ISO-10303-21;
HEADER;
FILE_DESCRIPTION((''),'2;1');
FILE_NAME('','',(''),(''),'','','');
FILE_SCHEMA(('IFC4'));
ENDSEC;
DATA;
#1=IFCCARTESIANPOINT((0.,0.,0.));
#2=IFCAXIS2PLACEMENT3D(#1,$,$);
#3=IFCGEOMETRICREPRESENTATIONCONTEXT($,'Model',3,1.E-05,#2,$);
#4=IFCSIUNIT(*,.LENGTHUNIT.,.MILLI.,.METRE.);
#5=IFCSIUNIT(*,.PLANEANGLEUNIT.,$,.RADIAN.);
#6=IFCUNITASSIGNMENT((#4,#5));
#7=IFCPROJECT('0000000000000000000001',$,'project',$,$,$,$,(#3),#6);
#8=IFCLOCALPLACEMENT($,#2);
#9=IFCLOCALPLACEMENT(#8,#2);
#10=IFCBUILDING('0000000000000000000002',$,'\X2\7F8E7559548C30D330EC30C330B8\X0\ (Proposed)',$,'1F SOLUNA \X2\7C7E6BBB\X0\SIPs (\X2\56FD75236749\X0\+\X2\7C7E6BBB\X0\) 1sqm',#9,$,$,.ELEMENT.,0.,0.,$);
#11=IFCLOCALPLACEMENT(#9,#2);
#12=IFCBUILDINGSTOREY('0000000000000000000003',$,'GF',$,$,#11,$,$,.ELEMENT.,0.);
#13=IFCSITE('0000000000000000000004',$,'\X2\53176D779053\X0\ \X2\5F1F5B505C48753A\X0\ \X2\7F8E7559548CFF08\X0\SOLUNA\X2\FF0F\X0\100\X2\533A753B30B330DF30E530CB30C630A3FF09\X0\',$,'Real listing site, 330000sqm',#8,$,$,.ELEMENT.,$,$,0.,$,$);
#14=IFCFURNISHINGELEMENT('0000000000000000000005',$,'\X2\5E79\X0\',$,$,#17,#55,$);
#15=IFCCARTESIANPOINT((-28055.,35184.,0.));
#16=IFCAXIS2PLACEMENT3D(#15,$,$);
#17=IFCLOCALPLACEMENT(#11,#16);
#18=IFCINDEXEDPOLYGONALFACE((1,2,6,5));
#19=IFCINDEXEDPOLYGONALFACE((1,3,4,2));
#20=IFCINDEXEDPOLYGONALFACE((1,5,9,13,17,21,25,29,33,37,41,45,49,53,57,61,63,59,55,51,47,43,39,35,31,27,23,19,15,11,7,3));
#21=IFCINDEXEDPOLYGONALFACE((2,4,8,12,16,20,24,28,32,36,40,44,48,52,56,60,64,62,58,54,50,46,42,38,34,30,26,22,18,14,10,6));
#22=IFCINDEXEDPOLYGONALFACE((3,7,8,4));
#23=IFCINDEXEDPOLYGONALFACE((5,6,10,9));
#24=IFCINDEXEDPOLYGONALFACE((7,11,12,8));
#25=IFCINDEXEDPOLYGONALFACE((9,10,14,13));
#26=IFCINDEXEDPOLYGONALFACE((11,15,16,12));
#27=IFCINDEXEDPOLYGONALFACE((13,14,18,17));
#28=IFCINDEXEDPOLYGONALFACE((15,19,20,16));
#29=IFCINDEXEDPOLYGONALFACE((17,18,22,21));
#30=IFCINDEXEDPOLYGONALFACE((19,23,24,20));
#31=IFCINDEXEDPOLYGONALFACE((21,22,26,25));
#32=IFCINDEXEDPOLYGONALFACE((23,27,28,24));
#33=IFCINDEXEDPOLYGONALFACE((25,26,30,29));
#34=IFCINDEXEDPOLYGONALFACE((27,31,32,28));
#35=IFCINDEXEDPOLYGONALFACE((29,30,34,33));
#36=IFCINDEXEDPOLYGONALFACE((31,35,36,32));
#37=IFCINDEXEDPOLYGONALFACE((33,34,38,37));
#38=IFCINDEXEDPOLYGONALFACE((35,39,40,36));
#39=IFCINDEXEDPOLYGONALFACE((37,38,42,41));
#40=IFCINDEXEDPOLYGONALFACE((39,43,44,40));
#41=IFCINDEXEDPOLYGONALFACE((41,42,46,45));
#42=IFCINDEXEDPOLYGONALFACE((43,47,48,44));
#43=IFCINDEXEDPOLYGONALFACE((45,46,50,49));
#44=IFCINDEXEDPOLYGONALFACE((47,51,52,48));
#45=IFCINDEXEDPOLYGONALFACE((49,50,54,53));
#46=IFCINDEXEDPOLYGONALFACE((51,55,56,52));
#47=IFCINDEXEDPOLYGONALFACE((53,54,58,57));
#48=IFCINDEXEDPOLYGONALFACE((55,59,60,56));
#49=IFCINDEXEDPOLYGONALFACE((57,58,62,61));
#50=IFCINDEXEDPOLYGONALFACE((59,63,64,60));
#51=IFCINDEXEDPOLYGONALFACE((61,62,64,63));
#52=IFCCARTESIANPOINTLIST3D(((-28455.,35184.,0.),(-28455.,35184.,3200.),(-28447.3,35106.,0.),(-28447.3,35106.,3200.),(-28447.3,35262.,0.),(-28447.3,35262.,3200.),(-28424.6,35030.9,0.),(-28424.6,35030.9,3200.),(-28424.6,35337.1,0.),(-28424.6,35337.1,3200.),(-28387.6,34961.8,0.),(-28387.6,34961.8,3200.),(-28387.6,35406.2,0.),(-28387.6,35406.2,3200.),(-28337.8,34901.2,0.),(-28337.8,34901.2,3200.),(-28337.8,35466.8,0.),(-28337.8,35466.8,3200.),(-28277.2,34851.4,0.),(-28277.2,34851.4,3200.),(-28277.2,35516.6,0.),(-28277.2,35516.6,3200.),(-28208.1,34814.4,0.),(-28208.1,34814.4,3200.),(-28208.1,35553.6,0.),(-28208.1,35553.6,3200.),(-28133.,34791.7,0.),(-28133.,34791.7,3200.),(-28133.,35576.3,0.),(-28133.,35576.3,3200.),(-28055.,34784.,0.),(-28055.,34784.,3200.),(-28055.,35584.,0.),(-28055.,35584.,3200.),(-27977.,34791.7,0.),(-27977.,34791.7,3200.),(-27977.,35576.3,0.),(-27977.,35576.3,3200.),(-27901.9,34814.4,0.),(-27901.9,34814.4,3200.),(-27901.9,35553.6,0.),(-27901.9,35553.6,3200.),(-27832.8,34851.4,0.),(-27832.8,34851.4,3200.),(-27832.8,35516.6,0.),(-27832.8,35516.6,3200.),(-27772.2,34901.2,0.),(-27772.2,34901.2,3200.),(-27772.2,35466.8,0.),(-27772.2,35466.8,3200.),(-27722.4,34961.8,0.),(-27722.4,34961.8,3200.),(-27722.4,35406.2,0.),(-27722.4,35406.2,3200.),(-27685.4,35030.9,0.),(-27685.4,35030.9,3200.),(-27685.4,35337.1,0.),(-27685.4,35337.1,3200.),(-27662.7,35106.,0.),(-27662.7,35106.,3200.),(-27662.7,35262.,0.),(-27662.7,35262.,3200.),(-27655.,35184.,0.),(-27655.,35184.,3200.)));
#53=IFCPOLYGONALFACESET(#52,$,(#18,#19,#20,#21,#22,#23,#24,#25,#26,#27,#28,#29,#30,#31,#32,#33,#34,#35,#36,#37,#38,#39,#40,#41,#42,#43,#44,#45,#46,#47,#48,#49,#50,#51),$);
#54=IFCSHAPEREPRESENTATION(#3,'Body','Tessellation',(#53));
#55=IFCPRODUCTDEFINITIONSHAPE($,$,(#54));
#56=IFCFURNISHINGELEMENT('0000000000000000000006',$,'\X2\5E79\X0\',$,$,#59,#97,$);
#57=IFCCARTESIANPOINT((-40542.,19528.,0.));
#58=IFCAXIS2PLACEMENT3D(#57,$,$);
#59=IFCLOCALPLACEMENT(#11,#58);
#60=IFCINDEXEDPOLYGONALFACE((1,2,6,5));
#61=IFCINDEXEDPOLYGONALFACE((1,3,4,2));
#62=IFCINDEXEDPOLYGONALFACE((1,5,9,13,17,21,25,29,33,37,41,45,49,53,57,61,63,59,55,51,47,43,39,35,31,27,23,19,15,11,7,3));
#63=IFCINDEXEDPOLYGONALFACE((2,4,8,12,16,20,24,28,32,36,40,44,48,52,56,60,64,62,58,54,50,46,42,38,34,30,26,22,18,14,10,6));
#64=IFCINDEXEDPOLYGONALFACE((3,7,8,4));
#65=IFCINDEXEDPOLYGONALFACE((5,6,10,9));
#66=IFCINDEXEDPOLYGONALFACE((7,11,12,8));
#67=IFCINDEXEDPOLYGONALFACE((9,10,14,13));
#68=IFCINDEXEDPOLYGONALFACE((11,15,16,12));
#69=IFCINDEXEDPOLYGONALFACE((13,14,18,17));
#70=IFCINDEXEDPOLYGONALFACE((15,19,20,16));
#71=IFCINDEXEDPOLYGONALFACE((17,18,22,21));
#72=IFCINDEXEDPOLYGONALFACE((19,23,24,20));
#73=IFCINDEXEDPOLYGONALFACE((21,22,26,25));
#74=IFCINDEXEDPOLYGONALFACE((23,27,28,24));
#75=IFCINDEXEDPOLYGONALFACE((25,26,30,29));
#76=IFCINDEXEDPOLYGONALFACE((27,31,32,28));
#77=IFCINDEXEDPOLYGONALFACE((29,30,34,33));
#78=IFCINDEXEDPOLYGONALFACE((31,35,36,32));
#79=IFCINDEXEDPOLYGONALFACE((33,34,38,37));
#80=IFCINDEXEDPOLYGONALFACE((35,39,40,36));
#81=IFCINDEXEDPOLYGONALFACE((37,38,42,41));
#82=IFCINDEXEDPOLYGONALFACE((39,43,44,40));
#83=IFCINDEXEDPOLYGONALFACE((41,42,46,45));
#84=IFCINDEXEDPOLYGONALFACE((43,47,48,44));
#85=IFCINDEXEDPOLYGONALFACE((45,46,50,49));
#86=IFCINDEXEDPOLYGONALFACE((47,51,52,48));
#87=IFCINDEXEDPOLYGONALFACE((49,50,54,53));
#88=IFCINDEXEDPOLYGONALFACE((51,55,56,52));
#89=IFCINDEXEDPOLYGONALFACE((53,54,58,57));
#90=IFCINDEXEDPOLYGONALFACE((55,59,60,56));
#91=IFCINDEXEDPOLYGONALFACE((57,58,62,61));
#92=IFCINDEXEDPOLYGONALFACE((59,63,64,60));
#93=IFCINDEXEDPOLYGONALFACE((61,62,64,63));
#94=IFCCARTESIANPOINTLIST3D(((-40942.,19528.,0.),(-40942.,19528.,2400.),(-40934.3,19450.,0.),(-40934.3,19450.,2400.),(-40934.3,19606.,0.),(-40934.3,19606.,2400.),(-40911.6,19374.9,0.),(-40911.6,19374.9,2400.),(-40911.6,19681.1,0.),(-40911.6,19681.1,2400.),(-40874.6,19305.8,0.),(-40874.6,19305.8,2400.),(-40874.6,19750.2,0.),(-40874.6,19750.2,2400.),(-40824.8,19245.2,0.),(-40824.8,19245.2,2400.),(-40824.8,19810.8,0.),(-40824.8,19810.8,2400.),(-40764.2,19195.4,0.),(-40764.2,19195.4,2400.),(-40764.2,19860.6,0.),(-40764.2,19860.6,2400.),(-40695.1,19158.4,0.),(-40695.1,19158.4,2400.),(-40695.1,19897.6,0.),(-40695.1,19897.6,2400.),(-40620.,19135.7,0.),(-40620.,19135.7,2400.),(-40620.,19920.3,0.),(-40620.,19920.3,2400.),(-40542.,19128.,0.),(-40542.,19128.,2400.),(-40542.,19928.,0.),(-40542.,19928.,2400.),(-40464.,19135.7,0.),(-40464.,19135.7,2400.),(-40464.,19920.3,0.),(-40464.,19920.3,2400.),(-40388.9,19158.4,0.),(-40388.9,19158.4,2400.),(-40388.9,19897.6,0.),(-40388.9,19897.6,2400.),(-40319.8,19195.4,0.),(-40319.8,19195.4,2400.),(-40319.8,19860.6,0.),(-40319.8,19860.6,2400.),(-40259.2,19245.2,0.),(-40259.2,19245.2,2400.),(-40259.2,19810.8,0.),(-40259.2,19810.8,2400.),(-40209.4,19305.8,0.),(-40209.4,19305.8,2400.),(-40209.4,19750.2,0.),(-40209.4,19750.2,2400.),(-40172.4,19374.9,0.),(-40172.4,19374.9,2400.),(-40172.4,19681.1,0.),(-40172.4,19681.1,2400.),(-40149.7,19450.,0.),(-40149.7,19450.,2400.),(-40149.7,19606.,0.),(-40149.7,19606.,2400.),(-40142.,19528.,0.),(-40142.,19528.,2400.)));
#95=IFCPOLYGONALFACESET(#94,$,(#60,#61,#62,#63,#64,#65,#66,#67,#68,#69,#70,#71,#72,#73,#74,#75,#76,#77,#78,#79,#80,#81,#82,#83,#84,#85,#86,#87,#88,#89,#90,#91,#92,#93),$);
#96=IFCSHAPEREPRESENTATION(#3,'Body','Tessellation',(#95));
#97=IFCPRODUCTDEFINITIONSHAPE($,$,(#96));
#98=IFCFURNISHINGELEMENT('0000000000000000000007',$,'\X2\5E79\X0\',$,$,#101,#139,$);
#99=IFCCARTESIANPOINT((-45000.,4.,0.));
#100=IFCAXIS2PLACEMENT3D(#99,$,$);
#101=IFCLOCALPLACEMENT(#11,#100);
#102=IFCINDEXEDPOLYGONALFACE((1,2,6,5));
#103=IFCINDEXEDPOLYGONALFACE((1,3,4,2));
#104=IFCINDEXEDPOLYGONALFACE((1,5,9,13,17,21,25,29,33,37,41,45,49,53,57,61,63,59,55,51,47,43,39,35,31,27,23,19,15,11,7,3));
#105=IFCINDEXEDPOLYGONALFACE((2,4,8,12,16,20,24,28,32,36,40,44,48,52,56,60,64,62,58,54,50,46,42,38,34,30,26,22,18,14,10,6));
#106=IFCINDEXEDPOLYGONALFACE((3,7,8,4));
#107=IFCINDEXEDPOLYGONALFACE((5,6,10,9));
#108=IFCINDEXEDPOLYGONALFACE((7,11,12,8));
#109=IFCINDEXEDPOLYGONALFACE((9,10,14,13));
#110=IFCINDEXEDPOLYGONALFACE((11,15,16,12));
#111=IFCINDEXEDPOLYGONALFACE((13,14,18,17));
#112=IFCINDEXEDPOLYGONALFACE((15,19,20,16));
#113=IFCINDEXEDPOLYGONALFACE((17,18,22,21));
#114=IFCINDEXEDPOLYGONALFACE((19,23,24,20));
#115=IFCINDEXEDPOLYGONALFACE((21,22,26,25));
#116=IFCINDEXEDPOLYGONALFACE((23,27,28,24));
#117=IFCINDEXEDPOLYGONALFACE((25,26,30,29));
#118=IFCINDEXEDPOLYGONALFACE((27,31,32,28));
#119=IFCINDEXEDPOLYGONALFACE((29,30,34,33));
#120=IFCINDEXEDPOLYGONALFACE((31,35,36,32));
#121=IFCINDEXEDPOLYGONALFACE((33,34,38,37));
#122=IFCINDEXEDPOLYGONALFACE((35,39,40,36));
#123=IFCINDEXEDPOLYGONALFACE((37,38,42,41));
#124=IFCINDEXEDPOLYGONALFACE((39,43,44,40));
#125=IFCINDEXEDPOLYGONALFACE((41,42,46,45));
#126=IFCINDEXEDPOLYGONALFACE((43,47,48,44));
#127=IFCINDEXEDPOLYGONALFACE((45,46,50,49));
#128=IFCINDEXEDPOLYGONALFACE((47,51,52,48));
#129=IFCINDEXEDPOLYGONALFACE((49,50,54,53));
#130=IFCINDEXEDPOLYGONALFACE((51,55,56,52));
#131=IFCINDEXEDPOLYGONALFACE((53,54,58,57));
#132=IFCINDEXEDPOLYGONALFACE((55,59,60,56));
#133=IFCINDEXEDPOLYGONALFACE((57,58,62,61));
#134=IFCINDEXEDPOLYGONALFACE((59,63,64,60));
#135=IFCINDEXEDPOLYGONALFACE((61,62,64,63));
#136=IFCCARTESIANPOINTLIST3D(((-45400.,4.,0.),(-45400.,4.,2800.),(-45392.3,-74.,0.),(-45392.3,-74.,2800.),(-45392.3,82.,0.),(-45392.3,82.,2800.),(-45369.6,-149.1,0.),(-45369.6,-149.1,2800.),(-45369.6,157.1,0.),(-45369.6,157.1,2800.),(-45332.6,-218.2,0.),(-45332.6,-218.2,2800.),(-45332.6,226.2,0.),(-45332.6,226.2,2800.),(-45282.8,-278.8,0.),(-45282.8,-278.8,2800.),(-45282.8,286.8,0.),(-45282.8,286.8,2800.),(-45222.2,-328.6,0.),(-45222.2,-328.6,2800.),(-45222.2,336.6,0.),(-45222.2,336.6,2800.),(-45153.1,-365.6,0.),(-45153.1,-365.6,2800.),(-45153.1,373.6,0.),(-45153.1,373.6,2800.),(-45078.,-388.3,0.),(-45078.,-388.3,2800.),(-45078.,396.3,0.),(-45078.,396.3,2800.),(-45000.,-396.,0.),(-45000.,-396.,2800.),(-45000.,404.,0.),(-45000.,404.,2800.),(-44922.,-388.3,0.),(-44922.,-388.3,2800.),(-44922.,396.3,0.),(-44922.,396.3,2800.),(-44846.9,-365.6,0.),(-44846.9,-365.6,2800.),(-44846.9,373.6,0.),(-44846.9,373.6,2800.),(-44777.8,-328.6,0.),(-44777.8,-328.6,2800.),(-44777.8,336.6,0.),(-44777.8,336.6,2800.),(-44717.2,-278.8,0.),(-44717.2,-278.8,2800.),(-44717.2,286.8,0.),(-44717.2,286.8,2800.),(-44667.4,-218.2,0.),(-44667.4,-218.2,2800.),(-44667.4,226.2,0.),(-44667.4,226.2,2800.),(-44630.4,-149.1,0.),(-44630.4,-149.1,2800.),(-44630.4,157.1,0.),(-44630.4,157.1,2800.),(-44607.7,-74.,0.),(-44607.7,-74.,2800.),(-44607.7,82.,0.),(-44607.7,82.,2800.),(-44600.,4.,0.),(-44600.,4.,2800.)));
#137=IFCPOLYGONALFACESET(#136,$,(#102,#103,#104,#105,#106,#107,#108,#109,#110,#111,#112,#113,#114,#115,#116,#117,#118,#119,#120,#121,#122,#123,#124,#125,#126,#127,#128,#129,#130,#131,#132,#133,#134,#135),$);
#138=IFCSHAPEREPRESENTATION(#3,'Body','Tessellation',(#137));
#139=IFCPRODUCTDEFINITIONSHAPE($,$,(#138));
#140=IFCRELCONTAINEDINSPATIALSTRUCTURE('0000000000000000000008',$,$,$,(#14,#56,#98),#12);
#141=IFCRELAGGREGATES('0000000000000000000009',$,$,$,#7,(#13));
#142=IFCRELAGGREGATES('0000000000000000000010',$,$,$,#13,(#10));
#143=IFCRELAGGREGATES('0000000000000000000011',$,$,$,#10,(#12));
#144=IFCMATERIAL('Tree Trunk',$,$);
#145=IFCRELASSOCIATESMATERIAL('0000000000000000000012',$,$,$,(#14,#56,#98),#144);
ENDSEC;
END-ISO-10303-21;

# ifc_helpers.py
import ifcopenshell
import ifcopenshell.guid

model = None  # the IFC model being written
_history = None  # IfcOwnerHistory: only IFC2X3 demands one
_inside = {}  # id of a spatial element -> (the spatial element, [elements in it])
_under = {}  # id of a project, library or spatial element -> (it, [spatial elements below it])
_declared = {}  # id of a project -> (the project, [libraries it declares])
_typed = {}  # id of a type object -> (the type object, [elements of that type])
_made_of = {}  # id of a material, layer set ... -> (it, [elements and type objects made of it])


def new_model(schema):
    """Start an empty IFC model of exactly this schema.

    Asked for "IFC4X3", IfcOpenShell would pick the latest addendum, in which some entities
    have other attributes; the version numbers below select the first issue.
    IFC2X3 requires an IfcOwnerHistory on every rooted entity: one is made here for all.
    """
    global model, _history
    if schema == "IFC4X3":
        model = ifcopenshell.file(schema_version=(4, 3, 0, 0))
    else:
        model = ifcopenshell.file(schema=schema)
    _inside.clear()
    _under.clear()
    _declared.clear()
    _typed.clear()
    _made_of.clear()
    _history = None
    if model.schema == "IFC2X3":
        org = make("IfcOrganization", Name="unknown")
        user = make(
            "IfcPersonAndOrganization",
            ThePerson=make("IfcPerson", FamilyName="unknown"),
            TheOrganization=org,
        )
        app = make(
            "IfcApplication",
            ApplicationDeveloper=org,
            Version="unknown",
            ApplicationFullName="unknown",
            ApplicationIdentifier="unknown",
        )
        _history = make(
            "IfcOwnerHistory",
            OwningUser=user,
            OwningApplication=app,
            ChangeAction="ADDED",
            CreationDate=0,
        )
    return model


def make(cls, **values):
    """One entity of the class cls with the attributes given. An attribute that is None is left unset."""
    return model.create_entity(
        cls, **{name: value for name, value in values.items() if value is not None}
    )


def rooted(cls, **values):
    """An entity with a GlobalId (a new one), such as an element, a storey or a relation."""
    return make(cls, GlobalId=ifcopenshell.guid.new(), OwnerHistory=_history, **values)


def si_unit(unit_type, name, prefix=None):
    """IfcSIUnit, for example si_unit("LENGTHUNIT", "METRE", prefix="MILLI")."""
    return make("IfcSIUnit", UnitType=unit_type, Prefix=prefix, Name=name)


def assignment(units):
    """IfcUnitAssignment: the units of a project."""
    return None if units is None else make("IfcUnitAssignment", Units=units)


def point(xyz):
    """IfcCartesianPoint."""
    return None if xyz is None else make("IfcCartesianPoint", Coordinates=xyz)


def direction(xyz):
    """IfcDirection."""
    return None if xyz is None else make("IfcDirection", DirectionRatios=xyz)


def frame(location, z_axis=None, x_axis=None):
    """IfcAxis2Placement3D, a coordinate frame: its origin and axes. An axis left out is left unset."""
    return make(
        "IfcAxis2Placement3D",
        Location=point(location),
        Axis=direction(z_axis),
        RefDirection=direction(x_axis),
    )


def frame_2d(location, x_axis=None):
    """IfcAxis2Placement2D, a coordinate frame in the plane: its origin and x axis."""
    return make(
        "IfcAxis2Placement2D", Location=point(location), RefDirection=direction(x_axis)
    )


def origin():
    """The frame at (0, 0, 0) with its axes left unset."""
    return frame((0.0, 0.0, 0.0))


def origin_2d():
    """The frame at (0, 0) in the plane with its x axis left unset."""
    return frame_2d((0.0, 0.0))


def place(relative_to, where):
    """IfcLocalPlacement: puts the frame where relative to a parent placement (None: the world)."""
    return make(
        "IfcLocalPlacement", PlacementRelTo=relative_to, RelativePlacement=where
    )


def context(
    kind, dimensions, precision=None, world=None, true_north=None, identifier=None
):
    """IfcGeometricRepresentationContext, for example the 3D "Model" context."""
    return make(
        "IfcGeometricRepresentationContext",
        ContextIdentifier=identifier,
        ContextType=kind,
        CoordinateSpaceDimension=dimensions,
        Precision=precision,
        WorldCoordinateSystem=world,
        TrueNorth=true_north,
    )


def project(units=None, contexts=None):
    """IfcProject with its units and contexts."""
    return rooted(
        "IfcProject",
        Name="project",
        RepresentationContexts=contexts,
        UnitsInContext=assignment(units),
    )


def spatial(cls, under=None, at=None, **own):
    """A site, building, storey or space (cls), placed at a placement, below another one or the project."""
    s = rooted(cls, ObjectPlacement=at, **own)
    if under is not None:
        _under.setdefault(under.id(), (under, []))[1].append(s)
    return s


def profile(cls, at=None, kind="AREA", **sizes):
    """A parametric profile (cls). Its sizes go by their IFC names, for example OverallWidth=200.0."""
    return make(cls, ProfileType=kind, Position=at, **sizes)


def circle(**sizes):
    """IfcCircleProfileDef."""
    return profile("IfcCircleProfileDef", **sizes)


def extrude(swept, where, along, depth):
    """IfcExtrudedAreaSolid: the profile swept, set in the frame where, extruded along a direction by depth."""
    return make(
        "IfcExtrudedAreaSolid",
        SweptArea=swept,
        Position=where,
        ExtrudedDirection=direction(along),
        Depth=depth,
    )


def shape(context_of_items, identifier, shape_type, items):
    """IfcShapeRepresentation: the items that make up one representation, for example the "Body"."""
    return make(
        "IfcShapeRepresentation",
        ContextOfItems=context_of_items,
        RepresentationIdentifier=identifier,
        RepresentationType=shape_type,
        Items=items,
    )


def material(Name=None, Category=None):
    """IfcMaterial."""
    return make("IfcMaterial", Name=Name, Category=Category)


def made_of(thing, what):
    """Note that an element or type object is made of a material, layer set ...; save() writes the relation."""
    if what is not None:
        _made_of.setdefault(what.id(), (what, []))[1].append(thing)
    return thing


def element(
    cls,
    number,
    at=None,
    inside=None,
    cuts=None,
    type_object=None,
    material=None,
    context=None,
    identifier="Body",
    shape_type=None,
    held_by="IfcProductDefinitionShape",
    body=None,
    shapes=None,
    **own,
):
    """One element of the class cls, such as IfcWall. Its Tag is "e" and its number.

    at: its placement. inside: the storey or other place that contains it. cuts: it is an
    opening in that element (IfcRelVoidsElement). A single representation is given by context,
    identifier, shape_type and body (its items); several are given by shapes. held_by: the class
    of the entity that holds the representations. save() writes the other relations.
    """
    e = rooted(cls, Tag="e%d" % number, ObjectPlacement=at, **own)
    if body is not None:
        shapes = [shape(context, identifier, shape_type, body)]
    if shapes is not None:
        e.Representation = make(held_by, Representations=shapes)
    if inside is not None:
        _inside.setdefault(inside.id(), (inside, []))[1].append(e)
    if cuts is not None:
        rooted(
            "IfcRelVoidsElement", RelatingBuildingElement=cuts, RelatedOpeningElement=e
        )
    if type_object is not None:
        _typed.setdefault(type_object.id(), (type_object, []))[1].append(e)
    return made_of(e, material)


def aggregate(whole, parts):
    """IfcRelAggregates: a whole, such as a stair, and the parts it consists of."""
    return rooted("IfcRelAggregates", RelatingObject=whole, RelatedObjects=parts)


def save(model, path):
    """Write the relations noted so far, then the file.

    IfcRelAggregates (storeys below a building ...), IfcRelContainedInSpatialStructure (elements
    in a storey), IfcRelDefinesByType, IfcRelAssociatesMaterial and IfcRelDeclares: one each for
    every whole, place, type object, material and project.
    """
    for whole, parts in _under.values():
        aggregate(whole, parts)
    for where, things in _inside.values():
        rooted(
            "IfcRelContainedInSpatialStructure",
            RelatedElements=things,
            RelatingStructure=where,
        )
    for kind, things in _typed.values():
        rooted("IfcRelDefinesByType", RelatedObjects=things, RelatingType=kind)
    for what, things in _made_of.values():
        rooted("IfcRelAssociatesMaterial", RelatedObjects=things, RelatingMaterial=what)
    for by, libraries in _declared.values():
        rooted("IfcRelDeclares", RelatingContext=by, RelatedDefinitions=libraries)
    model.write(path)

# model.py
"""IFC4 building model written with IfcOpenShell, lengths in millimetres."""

from ifc_helpers import new_model, si_unit, frame, origin, origin_2d, place, context, project, spatial, circle, extrude, material, element, save


model = new_model("IFC4")

# Units and contexts
model_context = context("Model", 3, precision=1e-05, world=origin())
ifc_project = project(units=[si_unit("LENGTHUNIT", "METRE", prefix="MILLI"), si_unit("PLANEANGLEUNIT", "RADIAN")], contexts=[model_context])

# Site, building, storey
site_placement = place(None, origin())
site = spatial("IfcSite", under=ifc_project, at=site_placement, Name="北海道 弟子屈町 美留和（SOLUNA／100区画コミュニティ）", ObjectType="Real listing site, 330000sqm", CompositionType="ELEMENT", RefElevation=0.0)
building_placement = place(site_placement, origin())
building = spatial("IfcBuilding", under=site, at=building_placement, Name="美留和ビレッジ (Proposed)", ObjectType="1F SOLUNA 籾殻SIPs (国産杉+籾殻) 1sqm", CompositionType="ELEMENT", ElevationOfRefHeight=0.0, ElevationOfTerrain=0.0)
storey_placement = place(building_placement, origin())
storey = spatial("IfcBuildingStorey", under=building, at=storey_placement, Name="GF", CompositionType="ELEMENT", Elevation=0.0)

# Furnishing elements
ifc_material_1 = material(Name="Tree Trunk")
furnishing_1_placement = place(storey_placement, frame((-28055.0, 35184.0, 0.0)))
element("IfcFurnishingElement", 1, at=furnishing_1_placement, inside=storey, material=ifc_material_1, Name="幹", context=model_context, shape_type="SweptSolid", body=[
    extrude(circle(Radius=400.0, at=origin_2d()), frame((-28055.0, 35184.0, 0.0)), (0.0, 0.0, 1.0), 3200.0),
])
furnishing_2_placement = place(storey_placement, frame((-40542.0, 19528.0, 0.0)))
element("IfcFurnishingElement", 2, at=furnishing_2_placement, inside=storey, material=ifc_material_1, Name="幹", context=model_context, shape_type="SweptSolid", body=[
    extrude(circle(Radius=400.0, at=origin_2d()), frame((-40542.0, 19528.0, 0.0)), (0.0, 0.0, 1.0), 2400.0),
])
furnishing_3_placement = place(storey_placement, frame((-45000.0, 4.0, 0.0)))
element("IfcFurnishingElement", 3, at=furnishing_3_placement, inside=storey, material=ifc_material_1, Name="幹", context=model_context, shape_type="SweptSolid", body=[
    extrude(circle(Radius=400.0, at=origin_2d()), frame((-45000.0, 4.0, 0.0)), (0.0, 0.0, 1.0), 2800.0),
])

save(model, "model.ifc")
